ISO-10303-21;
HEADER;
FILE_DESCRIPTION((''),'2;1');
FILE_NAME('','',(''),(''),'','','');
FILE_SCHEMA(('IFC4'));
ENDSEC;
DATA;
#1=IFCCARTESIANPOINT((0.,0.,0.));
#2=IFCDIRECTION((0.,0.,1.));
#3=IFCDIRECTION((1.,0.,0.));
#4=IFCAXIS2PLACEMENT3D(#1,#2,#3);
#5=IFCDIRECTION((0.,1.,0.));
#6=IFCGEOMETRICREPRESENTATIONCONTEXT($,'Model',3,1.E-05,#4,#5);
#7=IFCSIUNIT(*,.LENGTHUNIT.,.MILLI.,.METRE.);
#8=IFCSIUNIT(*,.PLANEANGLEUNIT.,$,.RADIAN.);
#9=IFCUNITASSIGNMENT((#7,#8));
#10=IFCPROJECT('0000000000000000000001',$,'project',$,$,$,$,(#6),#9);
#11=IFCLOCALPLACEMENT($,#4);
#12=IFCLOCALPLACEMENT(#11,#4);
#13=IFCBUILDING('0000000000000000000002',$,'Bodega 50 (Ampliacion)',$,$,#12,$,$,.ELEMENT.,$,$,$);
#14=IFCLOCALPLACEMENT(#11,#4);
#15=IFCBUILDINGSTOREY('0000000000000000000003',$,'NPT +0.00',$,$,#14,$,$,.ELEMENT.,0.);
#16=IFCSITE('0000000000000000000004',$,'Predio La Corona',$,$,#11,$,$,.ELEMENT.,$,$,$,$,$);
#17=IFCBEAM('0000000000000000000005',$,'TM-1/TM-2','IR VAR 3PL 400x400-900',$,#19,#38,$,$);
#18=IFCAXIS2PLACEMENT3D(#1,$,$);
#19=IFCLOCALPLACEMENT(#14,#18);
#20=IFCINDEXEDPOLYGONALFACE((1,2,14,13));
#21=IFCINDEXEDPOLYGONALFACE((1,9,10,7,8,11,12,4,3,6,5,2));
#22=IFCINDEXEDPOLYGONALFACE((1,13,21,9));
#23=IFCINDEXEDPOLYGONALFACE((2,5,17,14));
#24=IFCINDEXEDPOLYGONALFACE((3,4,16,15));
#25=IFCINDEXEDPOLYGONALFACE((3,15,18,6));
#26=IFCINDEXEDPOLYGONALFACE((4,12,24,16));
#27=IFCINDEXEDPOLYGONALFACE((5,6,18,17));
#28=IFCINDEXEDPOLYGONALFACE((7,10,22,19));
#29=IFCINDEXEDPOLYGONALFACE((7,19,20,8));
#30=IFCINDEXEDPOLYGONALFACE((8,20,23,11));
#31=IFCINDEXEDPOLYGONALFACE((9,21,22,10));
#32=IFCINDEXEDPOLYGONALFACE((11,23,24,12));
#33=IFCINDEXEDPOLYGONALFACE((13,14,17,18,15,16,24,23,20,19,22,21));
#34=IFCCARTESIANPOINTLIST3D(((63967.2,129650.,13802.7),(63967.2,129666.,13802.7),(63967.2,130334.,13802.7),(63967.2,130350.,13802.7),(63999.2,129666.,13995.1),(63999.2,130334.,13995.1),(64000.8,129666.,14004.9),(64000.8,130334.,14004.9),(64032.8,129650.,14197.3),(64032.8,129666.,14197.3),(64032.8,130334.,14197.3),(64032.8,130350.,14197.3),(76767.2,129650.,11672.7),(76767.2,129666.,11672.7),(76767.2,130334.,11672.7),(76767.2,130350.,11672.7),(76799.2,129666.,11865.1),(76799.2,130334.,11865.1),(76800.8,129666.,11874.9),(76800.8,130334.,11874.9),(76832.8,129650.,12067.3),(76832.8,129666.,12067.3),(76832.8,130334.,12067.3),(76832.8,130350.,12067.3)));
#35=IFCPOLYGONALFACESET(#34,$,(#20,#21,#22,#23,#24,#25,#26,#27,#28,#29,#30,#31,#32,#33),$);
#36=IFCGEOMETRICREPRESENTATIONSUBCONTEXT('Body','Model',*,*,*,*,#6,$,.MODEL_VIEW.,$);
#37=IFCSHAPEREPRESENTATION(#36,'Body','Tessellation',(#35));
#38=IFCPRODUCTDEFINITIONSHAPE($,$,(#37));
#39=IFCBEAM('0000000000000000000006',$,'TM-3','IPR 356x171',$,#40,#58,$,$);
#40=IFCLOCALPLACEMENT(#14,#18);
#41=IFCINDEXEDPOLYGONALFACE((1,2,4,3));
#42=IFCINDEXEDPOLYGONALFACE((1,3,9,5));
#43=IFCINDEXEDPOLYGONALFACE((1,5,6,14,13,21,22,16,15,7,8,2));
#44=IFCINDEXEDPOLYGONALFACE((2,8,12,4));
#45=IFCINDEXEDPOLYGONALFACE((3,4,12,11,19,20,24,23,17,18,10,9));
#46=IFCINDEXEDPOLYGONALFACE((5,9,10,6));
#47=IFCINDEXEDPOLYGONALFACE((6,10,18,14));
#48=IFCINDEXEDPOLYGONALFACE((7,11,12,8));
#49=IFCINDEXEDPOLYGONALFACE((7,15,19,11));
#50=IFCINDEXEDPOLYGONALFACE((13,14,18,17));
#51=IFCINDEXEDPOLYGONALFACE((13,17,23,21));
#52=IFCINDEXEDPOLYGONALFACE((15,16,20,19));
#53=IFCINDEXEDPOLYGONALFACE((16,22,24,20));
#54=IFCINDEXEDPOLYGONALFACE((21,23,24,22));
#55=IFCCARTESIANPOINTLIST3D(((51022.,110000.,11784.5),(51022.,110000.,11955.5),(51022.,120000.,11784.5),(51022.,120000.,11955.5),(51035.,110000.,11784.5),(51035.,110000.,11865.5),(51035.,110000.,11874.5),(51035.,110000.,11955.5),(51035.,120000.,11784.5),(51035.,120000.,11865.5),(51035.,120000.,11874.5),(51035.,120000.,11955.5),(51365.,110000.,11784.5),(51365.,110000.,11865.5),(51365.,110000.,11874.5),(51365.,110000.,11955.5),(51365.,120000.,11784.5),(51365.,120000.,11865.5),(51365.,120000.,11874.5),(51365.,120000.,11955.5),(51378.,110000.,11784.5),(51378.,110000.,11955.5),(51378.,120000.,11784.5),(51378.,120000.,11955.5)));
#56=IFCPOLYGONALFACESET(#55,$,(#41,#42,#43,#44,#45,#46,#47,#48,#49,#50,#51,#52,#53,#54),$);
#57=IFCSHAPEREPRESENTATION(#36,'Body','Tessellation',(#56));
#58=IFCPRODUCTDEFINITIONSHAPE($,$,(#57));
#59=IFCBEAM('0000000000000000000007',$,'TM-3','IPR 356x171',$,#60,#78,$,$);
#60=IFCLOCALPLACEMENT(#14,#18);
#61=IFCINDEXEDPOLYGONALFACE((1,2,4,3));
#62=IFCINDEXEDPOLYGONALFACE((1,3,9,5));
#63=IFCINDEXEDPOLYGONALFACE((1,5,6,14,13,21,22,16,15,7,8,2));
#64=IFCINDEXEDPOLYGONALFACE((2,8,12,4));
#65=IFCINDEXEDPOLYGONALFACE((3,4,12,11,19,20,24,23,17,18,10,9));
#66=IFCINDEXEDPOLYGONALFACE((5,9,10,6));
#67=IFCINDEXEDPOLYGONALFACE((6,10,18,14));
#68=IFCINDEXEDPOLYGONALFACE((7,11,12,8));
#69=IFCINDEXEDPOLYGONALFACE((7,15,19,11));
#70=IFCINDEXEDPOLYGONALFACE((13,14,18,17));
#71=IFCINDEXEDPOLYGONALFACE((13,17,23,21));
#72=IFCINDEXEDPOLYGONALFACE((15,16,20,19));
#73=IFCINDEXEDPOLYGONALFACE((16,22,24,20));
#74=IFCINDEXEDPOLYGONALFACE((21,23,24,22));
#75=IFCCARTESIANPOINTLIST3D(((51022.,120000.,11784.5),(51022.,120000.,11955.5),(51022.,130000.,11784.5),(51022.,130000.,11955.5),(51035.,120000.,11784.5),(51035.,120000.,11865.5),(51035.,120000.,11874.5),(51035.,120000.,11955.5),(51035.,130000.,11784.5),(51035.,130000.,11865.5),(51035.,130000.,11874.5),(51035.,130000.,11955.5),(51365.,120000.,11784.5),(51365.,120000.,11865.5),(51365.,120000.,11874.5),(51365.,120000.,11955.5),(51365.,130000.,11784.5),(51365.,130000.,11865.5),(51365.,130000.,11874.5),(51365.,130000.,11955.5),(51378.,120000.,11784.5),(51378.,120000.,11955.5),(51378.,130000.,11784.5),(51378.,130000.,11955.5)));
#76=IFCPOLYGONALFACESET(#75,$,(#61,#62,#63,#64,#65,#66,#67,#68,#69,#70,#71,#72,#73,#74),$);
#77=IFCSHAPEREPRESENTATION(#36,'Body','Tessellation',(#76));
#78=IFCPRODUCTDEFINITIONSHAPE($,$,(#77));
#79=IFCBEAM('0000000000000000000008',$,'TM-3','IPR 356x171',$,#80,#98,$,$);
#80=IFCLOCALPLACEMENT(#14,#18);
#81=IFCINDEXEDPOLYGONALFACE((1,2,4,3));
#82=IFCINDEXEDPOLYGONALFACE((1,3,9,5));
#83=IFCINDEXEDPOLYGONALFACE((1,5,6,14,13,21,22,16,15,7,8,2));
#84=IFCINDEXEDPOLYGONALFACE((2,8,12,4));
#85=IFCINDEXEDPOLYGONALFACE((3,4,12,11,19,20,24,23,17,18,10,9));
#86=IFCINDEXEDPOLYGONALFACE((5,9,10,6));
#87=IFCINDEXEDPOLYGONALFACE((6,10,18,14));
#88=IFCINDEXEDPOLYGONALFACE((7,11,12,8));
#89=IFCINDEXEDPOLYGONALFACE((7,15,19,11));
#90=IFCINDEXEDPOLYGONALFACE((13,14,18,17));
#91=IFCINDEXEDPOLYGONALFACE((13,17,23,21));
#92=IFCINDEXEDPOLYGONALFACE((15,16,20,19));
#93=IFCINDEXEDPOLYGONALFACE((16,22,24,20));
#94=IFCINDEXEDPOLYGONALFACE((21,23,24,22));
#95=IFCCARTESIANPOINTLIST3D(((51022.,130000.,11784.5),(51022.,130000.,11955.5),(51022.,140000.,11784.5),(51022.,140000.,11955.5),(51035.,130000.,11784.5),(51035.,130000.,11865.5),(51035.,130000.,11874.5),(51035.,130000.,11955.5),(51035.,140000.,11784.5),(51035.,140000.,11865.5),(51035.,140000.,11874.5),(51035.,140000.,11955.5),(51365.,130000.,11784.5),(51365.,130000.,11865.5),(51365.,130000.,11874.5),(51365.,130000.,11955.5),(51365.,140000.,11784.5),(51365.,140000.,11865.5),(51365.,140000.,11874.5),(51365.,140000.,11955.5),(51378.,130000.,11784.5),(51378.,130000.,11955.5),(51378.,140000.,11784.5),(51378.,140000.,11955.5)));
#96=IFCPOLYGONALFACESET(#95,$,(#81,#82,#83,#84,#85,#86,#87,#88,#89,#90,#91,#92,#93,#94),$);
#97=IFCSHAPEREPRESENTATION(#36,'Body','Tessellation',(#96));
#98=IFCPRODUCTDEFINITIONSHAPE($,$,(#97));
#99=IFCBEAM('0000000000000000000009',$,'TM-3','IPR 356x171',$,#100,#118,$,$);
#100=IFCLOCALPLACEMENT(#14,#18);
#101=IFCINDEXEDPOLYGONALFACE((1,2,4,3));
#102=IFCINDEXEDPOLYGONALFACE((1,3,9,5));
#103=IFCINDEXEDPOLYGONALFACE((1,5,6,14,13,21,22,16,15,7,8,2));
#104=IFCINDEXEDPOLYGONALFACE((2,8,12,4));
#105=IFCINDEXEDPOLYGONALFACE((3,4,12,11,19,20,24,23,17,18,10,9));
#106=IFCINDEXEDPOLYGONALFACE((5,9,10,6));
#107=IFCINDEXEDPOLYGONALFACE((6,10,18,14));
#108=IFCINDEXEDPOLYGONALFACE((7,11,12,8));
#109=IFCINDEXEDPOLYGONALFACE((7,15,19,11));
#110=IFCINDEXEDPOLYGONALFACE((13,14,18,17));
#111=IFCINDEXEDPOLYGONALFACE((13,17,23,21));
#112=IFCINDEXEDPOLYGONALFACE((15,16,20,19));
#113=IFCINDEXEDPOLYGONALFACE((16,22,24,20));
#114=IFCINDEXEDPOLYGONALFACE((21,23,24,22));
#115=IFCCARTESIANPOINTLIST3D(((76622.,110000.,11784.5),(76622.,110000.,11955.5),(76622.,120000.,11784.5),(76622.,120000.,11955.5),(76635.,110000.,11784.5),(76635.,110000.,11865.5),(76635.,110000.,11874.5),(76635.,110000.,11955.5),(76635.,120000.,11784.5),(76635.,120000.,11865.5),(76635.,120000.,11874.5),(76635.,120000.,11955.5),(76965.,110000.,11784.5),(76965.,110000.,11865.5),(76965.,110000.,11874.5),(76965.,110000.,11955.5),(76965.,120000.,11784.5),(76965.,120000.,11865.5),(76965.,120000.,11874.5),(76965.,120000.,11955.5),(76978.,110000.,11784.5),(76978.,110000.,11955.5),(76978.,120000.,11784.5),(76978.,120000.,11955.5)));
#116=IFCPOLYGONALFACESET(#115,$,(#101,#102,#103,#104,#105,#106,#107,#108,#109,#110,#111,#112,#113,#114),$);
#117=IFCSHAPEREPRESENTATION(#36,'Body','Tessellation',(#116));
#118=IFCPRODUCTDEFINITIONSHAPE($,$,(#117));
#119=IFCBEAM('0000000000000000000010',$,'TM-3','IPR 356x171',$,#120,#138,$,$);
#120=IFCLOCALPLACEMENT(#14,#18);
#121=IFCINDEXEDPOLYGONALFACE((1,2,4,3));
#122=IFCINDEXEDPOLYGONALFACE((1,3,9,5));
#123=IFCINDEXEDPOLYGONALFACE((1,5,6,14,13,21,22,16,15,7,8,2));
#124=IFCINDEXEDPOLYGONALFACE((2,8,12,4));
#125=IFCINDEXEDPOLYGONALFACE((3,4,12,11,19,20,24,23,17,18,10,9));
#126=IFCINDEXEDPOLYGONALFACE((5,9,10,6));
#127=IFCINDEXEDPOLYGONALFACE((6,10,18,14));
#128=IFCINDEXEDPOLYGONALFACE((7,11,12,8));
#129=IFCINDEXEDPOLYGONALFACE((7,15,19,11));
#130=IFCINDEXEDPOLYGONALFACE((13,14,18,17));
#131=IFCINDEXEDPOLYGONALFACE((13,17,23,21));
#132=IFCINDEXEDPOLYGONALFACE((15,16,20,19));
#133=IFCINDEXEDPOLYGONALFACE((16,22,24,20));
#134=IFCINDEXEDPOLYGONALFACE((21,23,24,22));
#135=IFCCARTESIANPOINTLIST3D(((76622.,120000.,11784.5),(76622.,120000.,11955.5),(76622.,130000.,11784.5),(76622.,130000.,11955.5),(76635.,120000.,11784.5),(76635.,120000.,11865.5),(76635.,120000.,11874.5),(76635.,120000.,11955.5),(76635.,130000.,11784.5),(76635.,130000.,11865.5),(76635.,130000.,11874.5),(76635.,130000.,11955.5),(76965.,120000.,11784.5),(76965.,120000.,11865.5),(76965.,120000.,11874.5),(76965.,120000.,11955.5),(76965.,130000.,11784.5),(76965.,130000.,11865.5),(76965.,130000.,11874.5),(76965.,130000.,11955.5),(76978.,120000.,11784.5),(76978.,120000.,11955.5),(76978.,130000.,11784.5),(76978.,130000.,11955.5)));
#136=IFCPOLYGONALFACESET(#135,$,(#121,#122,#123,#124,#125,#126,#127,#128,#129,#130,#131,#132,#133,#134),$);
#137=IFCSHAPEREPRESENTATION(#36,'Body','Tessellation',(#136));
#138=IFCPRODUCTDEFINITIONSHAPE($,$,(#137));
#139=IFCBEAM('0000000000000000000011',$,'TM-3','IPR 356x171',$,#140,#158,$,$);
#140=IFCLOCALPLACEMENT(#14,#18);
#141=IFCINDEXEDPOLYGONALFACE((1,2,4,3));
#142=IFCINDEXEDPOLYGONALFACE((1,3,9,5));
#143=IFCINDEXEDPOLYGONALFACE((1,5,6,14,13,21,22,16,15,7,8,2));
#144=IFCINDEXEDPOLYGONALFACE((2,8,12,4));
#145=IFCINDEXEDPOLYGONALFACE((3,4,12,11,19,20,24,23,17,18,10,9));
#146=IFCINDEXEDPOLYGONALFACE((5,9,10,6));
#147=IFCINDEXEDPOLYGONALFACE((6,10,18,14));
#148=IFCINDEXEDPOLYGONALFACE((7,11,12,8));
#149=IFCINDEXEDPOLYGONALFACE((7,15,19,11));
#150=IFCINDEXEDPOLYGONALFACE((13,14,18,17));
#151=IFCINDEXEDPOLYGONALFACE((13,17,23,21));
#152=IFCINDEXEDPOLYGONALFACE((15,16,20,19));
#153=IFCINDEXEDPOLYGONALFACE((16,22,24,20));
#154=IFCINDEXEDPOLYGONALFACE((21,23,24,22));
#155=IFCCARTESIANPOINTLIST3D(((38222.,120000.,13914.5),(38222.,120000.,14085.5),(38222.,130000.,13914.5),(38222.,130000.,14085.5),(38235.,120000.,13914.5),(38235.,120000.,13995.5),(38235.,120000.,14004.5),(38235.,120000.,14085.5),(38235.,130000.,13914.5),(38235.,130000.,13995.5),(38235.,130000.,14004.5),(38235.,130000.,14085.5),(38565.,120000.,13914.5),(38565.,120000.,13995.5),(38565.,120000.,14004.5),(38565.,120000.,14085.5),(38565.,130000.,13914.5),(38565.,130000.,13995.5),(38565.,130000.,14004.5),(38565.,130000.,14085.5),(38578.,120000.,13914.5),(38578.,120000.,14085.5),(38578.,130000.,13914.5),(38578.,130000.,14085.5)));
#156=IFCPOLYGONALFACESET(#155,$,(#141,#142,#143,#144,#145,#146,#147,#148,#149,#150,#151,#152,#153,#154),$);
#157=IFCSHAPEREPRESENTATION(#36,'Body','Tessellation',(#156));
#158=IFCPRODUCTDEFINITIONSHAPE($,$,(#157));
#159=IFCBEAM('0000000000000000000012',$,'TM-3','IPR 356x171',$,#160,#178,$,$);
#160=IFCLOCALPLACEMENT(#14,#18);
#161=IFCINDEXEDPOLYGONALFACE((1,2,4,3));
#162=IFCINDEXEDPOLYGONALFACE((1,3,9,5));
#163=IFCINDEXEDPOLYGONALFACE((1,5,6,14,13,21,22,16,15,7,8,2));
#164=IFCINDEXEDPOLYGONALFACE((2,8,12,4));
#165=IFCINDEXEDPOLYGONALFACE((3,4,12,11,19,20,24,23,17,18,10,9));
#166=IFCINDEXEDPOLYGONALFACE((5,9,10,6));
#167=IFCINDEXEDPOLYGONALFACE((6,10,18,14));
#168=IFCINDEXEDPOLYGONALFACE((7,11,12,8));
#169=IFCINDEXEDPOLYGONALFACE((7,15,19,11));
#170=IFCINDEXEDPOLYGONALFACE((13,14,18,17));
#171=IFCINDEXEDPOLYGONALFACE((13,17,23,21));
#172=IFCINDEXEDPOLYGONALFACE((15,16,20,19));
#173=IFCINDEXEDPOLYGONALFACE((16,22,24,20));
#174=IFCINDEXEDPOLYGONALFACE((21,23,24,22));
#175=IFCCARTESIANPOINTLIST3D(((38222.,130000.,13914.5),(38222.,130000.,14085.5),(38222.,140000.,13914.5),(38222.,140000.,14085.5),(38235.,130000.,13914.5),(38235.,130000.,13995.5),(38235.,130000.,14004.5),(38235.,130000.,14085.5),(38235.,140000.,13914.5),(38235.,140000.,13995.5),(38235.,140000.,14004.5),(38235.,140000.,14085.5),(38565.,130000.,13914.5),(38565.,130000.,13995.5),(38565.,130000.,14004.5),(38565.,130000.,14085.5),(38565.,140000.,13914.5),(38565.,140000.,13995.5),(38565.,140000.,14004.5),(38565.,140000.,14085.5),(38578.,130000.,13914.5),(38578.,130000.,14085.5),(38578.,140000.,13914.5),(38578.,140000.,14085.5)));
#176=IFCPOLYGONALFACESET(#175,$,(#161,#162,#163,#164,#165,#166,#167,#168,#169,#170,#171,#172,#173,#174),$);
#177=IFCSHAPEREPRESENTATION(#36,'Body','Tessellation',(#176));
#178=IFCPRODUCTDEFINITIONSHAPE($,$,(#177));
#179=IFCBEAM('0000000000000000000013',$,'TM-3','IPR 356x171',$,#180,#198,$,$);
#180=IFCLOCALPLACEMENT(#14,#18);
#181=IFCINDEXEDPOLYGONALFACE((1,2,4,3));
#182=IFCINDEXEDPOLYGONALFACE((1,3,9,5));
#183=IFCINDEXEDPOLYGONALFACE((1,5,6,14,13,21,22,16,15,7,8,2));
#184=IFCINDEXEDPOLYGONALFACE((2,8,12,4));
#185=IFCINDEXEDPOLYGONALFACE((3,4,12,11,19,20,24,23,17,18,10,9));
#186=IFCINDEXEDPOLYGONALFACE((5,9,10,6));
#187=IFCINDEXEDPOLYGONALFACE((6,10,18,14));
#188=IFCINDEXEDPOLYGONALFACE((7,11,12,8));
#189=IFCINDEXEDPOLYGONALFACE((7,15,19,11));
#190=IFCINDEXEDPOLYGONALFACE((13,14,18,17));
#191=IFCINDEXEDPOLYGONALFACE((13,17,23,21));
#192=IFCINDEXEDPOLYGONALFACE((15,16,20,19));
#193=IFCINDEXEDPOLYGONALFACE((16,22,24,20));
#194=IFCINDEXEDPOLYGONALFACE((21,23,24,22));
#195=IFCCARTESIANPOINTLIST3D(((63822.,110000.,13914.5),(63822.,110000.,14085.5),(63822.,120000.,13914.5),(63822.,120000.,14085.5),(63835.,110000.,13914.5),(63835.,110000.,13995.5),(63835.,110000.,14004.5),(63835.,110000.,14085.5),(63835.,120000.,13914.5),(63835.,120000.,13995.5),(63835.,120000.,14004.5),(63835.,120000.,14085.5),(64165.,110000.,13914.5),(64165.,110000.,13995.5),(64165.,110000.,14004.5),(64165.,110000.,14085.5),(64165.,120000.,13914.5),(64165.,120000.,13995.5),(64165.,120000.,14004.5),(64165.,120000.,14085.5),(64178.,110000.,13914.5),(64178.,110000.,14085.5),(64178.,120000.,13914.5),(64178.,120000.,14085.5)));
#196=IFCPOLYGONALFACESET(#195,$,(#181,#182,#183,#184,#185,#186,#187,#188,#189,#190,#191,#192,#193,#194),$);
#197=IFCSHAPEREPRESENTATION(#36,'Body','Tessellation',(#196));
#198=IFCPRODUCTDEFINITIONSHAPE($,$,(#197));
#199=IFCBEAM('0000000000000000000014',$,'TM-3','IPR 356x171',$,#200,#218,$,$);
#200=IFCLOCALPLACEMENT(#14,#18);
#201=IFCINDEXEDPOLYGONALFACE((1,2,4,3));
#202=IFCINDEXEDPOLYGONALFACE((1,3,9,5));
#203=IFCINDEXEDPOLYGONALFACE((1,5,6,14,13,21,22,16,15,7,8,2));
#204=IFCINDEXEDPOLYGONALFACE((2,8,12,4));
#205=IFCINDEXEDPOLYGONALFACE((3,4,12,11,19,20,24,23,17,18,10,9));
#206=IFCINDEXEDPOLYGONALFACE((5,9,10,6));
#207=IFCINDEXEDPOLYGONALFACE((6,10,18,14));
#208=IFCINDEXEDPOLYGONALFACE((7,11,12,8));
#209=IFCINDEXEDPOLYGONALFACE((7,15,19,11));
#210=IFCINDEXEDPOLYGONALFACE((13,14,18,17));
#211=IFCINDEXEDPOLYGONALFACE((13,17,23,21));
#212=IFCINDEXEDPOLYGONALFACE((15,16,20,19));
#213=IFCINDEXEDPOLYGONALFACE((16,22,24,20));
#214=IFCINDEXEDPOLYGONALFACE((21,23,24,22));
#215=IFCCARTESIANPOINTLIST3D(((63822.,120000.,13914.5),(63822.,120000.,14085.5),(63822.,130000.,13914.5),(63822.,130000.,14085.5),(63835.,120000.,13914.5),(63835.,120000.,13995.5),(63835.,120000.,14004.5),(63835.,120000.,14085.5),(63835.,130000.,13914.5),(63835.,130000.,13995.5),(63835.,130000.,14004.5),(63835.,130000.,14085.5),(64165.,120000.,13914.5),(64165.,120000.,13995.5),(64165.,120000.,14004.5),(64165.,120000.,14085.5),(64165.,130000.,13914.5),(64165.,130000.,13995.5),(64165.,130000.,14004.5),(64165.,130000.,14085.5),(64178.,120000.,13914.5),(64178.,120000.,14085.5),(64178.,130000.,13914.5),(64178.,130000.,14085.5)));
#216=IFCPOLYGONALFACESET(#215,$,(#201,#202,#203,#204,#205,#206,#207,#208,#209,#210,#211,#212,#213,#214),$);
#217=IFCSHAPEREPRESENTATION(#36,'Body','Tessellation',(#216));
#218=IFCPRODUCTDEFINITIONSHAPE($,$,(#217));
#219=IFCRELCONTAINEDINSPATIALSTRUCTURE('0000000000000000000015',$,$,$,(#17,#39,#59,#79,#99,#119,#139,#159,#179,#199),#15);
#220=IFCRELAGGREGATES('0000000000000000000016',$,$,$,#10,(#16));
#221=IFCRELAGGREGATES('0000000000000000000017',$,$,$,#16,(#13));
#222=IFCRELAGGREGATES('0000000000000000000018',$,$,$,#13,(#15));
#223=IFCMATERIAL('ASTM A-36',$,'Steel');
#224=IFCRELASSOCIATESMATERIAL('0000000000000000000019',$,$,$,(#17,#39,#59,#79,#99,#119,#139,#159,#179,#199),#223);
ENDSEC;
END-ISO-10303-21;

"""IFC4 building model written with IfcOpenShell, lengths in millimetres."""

from ifc_helpers import new_model, si_unit, direction, frame, origin_with_axes, origin_2d, place, context, subcontext, project, spatial, i_section, extrude, material, element, save


model = new_model("IFC4")

# Units and contexts
model_context = context("Model", 3, precision=1e-05, world=origin_with_axes(), true_north=direction((0.0, 1.0, 0.0)))
body_context = subcontext(model_context, "Body", "Model", "MODEL_VIEW")
ifc_project = project(units=[si_unit("LENGTHUNIT", "METRE", prefix="MILLI"), si_unit("PLANEANGLEUNIT", "RADIAN")], contexts=[model_context])

# Site, building, storey
site_placement = place(None, origin_with_axes())
site = spatial("IfcSite", under=ifc_project, at=site_placement, Name="Predio La Corona", CompositionType="ELEMENT")
building_placement = place(site_placement, origin_with_axes())
building = spatial("IfcBuilding", under=site, at=building_placement, Name="Bodega 50 (Ampliacion)", CompositionType="ELEMENT")
storey_placement = place(site_placement, origin_with_axes())
storey = spatial("IfcBuildingStorey", under=building, at=storey_placement, Name="NPT +0.00", CompositionType="ELEMENT", Elevation=0.0)

# Shared definitions
ifc_material = material(Name="ASTM A-36", Category="Steel")

# Beams
for number, where, z_axis, x_axis, name in (
    (1, (64000.0, 130000.0, 14000.0), (0.986436, 0.0, -0.164149), (-0.164149, 0.0, -0.986436), "TM-1/TM-2"),
):
    element("IfcBeam", number, at=place(storey_placement, frame(where, z_axis=z_axis, x_axis=x_axis)), inside=storey, material=ifc_material, Name=name, Description="IR VAR 3PL 400x400-900", context=body_context, shape_type="SweptSolid", body=[
        extrude(i_section(OverallWidth=400.0, OverallDepth=700.0, WebThickness=10.0, FlangeThickness=16.0, at=origin_2d()), origin_with_axes(), (0.0, 0.0, 1.0), 12976.0),
    ])
for number, where, z_axis, x_axis, name in (
    (2, (51200.0, 110000.0, 11870.0), (0.0, 1.0, 0.0), (0.0, 0.0, 1.0), "TM-3"),
    (3, (51200.0, 120000.0, 11870.0), (0.0, 1.0, 0.0), (0.0, 0.0, 1.0), "TM-3"),
    (4, (51200.0, 130000.0, 11870.0), (0.0, 1.0, 0.0), (0.0, 0.0, 1.0), "TM-3"),
    (5, (76800.0, 110000.0, 11870.0), (0.0, 1.0, 0.0), (0.0, 0.0, 1.0), "TM-3"),
    (6, (76800.0, 120000.0, 11870.0), (0.0, 1.0, 0.0), (0.0, 0.0, 1.0), "TM-3"),
    (7, (38400.0, 120000.0, 14000.0), (0.0, 1.0, 0.0), (0.0, 0.0, 1.0), "TM-3"),
    (8, (38400.0, 130000.0, 14000.0), (0.0, 1.0, 0.0), (0.0, 0.0, 1.0), "TM-3"),
    (9, (64000.0, 110000.0, 14000.0), (0.0, 1.0, 0.0), (0.0, 0.0, 1.0), "TM-3"),
    (10, (64000.0, 120000.0, 14000.0), (0.0, 1.0, 0.0), (0.0, 0.0, 1.0), "TM-3"),
):
    element("IfcBeam", number, at=place(storey_placement, frame(where, z_axis=z_axis, x_axis=x_axis)), inside=storey, material=ifc_material, Name=name, Description="IPR 356x171", context=body_context, shape_type="SweptSolid", body=[
        extrude(i_section(OverallWidth=171.0, OverallDepth=356.0, WebThickness=9.0, FlangeThickness=13.0, at=origin_2d()), origin_with_axes(), (0.0, 0.0, 1.0), 10000.0),
    ])

save(model, "model.ifc")
